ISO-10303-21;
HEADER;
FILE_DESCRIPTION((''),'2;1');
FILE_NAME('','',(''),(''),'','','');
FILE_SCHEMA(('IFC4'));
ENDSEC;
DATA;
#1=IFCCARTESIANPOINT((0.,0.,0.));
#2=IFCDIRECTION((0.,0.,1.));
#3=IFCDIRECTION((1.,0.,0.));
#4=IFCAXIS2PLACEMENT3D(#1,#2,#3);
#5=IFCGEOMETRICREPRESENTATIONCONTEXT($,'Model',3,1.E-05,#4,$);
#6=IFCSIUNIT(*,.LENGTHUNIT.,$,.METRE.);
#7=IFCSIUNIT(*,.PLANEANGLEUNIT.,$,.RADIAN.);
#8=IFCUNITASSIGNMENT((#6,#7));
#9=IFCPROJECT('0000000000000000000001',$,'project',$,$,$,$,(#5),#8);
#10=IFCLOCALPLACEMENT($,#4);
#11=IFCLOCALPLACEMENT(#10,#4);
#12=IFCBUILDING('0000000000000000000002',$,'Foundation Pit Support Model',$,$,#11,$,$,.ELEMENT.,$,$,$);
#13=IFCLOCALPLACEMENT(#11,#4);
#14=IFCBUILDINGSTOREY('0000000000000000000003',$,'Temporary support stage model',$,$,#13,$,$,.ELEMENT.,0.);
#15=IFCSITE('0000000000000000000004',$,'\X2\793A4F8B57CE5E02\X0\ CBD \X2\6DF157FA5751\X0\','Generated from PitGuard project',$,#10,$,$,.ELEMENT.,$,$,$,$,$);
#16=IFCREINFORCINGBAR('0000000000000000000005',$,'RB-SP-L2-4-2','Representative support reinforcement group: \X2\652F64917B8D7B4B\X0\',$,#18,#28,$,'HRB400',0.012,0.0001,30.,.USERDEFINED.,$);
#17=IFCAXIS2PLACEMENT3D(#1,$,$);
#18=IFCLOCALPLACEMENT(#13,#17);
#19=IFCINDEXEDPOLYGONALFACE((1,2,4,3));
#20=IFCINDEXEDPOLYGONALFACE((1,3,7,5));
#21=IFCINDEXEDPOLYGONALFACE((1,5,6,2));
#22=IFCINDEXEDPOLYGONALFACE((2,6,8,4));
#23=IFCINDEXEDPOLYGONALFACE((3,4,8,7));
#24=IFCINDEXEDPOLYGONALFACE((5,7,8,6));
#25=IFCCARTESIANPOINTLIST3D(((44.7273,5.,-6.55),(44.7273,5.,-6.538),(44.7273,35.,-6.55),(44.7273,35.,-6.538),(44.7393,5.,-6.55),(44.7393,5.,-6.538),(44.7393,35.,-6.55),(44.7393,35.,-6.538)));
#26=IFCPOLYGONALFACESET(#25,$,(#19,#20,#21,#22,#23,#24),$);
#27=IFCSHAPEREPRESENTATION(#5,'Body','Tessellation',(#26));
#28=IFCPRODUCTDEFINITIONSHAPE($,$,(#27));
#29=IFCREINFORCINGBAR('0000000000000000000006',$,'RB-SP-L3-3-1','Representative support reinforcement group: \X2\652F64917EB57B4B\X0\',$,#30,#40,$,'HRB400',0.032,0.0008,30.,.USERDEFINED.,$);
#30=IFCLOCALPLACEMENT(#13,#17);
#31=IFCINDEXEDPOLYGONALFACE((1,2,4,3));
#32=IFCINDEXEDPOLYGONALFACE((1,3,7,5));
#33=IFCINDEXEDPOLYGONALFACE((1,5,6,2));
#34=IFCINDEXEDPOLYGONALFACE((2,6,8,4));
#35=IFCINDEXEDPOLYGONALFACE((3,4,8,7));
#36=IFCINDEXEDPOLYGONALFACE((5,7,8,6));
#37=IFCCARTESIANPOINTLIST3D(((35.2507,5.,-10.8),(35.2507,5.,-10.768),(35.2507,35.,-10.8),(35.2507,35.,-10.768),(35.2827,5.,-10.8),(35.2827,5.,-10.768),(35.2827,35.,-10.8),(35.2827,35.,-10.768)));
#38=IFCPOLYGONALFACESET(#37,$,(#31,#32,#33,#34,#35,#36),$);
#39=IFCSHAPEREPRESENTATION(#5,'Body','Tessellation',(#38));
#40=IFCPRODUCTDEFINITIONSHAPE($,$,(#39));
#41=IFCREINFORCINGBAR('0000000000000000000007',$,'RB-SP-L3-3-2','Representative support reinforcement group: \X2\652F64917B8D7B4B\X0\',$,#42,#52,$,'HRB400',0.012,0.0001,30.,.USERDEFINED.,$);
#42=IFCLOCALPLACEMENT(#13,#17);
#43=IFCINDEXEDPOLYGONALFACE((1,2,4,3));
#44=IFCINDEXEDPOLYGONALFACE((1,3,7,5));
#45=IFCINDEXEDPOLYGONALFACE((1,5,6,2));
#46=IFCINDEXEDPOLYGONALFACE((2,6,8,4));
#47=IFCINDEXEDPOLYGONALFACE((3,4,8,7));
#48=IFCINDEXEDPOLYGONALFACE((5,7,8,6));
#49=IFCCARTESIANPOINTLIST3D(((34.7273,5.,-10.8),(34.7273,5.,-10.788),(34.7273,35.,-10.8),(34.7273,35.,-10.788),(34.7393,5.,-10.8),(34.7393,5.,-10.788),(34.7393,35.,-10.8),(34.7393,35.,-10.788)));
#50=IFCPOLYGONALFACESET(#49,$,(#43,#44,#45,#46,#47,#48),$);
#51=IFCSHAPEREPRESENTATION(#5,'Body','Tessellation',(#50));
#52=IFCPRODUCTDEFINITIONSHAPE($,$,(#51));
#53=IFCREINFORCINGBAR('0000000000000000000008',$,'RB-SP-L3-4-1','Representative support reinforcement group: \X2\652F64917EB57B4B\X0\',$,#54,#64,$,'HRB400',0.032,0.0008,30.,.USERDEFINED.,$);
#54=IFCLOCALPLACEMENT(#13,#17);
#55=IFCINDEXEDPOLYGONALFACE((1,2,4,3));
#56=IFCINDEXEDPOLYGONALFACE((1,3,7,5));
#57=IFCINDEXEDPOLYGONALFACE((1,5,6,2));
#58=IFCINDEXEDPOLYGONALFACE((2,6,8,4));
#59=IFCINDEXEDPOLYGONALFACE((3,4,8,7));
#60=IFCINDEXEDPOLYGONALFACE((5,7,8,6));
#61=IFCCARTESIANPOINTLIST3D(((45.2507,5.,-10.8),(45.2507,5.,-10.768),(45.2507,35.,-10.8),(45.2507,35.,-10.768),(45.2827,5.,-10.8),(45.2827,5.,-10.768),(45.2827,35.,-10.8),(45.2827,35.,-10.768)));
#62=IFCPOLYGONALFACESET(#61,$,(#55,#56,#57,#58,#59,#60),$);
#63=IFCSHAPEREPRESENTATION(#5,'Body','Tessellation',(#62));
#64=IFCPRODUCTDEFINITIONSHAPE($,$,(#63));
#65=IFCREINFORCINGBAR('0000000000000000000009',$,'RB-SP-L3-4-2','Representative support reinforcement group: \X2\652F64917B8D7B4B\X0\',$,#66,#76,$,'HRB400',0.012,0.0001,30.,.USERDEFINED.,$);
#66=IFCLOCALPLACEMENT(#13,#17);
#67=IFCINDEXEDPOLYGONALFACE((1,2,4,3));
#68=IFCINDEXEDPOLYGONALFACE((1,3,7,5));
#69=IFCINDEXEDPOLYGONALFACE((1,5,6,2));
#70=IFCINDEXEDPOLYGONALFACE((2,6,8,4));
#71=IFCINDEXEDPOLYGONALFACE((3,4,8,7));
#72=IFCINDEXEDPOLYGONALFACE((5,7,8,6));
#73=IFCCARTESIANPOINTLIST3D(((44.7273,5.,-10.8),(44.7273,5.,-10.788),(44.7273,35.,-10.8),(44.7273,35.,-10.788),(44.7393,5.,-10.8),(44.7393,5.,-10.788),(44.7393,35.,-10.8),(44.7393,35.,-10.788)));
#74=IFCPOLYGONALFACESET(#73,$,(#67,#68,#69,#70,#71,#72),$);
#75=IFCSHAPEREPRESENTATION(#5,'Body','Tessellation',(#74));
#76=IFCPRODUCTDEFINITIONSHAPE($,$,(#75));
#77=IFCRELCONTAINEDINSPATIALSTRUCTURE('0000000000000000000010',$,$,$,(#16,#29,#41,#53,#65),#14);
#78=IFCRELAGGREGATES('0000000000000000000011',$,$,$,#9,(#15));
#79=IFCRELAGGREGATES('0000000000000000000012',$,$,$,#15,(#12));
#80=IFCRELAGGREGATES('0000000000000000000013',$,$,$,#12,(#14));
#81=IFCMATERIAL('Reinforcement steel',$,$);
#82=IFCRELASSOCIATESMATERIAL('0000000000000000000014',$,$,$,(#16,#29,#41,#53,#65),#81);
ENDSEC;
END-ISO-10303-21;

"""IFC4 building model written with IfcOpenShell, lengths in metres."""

from ifc_helpers import new_model, si_unit, frame, origin_with_axes, origin_2d, place, context, project, spatial, rectangle, extrude, material, element, save


model = new_model("IFC4")

# Units and contexts
model_context = context("Model", 3, precision=1e-05, world=origin_with_axes())
ifc_project = project(units=[si_unit("LENGTHUNIT", "METRE"), si_unit("PLANEANGLEUNIT", "RADIAN")], contexts=[model_context])

# Site, building, storey
site_placement = place(None, origin_with_axes())
site = spatial("IfcSite", under=ifc_project, at=site_placement, Name="示例城市 CBD 深基坑", Description="Generated from PitGuard project", CompositionType="ELEMENT")
building_placement = place(site_placement, origin_with_axes())
building = spatial("IfcBuilding", under=site, at=building_placement, Name="Foundation Pit Support Model", CompositionType="ELEMENT")
storey_placement = place(building_placement, origin_with_axes())
storey = spatial("IfcBuildingStorey", under=building, at=storey_placement, Name="Temporary support stage model", CompositionType="ELEMENT", Elevation=0.0)

# Reinforcing bars
ifc_material_1 = material(Name="Reinforcement steel")
reinforcing_bar_1_placement = place(storey_placement, frame((44.7333, 20.0, -6.55), z_axis=(0.0, 0.0, 1.0), x_axis=(0.0, 1.0, 0.0)))
element("IfcReinforcingBar", 1, at=reinforcing_bar_1_placement, inside=storey, material=ifc_material_1, Name="RB-SP-L2-4-2", Description="Representative support reinforcement group: 支撑箍筋", SteelGrade="HRB400", BarLength=30.0, CrossSectionArea=0.0001, NominalDiameter=0.012, PredefinedType="USERDEFINED", context=model_context, shape_type="SweptSolid", body=[
    extrude(rectangle(XDim=30.0, YDim=0.012, at=origin_2d()), origin_with_axes(), (0.0, 0.0, 1.0), 0.012),
])
reinforcing_bar_2_placement = place(storey_placement, frame((35.2667, 20.0, -10.8), z_axis=(0.0, 0.0, 1.0), x_axis=(0.0, 1.0, 0.0)))
element("IfcReinforcingBar", 2, at=reinforcing_bar_2_placement, inside=storey, material=ifc_material_1, Name="RB-SP-L3-3-1", Description="Representative support reinforcement group: 支撑纵筋", SteelGrade="HRB400", BarLength=30.0, CrossSectionArea=0.0008, NominalDiameter=0.032, PredefinedType="USERDEFINED", context=model_context, shape_type="SweptSolid", body=[
    extrude(rectangle(XDim=30.0, YDim=0.032, at=origin_2d()), origin_with_axes(), (0.0, 0.0, 1.0), 0.032),
])
reinforcing_bar_3_placement = place(storey_placement, frame((34.7333, 20.0, -10.8), z_axis=(0.0, 0.0, 1.0), x_axis=(0.0, 1.0, 0.0)))
element("IfcReinforcingBar", 3, at=reinforcing_bar_3_placement, inside=storey, material=ifc_material_1, Name="RB-SP-L3-3-2", Description="Representative support reinforcement group: 支撑箍筋", SteelGrade="HRB400", BarLength=30.0, CrossSectionArea=0.0001, NominalDiameter=0.012, PredefinedType="USERDEFINED", context=model_context, shape_type="SweptSolid", body=[
    extrude(rectangle(XDim=30.0, YDim=0.012, at=origin_2d()), origin_with_axes(), (0.0, 0.0, 1.0), 0.012),
])
reinforcing_bar_4_placement = place(storey_placement, frame((45.2667, 20.0, -10.8), z_axis=(0.0, 0.0, 1.0), x_axis=(0.0, 1.0, 0.0)))
element("IfcReinforcingBar", 4, at=reinforcing_bar_4_placement, inside=storey, material=ifc_material_1, Name="RB-SP-L3-4-1", Description="Representative support reinforcement group: 支撑纵筋", SteelGrade="HRB400", BarLength=30.0, CrossSectionArea=0.0008, NominalDiameter=0.032, PredefinedType="USERDEFINED", context=model_context, shape_type="SweptSolid", body=[
    extrude(rectangle(XDim=30.0, YDim=0.032, at=origin_2d()), origin_with_axes(), (0.0, 0.0, 1.0), 0.032),
])
reinforcing_bar_5_placement = place(storey_placement, frame((44.7333, 20.0, -10.8), z_axis=(0.0, 0.0, 1.0), x_axis=(0.0, 1.0, 0.0)))
element("IfcReinforcingBar", 5, at=reinforcing_bar_5_placement, inside=storey, material=ifc_material_1, Name="RB-SP-L3-4-2", Description="Representative support reinforcement group: 支撑箍筋", SteelGrade="HRB400", BarLength=30.0, CrossSectionArea=0.0001, NominalDiameter=0.012, PredefinedType="USERDEFINED", context=model_context, shape_type="SweptSolid", body=[
    extrude(rectangle(XDim=30.0, YDim=0.012, at=origin_2d()), origin_with_axes(), (0.0, 0.0, 1.0), 0.012),
])

save(model, "model.ifc")
